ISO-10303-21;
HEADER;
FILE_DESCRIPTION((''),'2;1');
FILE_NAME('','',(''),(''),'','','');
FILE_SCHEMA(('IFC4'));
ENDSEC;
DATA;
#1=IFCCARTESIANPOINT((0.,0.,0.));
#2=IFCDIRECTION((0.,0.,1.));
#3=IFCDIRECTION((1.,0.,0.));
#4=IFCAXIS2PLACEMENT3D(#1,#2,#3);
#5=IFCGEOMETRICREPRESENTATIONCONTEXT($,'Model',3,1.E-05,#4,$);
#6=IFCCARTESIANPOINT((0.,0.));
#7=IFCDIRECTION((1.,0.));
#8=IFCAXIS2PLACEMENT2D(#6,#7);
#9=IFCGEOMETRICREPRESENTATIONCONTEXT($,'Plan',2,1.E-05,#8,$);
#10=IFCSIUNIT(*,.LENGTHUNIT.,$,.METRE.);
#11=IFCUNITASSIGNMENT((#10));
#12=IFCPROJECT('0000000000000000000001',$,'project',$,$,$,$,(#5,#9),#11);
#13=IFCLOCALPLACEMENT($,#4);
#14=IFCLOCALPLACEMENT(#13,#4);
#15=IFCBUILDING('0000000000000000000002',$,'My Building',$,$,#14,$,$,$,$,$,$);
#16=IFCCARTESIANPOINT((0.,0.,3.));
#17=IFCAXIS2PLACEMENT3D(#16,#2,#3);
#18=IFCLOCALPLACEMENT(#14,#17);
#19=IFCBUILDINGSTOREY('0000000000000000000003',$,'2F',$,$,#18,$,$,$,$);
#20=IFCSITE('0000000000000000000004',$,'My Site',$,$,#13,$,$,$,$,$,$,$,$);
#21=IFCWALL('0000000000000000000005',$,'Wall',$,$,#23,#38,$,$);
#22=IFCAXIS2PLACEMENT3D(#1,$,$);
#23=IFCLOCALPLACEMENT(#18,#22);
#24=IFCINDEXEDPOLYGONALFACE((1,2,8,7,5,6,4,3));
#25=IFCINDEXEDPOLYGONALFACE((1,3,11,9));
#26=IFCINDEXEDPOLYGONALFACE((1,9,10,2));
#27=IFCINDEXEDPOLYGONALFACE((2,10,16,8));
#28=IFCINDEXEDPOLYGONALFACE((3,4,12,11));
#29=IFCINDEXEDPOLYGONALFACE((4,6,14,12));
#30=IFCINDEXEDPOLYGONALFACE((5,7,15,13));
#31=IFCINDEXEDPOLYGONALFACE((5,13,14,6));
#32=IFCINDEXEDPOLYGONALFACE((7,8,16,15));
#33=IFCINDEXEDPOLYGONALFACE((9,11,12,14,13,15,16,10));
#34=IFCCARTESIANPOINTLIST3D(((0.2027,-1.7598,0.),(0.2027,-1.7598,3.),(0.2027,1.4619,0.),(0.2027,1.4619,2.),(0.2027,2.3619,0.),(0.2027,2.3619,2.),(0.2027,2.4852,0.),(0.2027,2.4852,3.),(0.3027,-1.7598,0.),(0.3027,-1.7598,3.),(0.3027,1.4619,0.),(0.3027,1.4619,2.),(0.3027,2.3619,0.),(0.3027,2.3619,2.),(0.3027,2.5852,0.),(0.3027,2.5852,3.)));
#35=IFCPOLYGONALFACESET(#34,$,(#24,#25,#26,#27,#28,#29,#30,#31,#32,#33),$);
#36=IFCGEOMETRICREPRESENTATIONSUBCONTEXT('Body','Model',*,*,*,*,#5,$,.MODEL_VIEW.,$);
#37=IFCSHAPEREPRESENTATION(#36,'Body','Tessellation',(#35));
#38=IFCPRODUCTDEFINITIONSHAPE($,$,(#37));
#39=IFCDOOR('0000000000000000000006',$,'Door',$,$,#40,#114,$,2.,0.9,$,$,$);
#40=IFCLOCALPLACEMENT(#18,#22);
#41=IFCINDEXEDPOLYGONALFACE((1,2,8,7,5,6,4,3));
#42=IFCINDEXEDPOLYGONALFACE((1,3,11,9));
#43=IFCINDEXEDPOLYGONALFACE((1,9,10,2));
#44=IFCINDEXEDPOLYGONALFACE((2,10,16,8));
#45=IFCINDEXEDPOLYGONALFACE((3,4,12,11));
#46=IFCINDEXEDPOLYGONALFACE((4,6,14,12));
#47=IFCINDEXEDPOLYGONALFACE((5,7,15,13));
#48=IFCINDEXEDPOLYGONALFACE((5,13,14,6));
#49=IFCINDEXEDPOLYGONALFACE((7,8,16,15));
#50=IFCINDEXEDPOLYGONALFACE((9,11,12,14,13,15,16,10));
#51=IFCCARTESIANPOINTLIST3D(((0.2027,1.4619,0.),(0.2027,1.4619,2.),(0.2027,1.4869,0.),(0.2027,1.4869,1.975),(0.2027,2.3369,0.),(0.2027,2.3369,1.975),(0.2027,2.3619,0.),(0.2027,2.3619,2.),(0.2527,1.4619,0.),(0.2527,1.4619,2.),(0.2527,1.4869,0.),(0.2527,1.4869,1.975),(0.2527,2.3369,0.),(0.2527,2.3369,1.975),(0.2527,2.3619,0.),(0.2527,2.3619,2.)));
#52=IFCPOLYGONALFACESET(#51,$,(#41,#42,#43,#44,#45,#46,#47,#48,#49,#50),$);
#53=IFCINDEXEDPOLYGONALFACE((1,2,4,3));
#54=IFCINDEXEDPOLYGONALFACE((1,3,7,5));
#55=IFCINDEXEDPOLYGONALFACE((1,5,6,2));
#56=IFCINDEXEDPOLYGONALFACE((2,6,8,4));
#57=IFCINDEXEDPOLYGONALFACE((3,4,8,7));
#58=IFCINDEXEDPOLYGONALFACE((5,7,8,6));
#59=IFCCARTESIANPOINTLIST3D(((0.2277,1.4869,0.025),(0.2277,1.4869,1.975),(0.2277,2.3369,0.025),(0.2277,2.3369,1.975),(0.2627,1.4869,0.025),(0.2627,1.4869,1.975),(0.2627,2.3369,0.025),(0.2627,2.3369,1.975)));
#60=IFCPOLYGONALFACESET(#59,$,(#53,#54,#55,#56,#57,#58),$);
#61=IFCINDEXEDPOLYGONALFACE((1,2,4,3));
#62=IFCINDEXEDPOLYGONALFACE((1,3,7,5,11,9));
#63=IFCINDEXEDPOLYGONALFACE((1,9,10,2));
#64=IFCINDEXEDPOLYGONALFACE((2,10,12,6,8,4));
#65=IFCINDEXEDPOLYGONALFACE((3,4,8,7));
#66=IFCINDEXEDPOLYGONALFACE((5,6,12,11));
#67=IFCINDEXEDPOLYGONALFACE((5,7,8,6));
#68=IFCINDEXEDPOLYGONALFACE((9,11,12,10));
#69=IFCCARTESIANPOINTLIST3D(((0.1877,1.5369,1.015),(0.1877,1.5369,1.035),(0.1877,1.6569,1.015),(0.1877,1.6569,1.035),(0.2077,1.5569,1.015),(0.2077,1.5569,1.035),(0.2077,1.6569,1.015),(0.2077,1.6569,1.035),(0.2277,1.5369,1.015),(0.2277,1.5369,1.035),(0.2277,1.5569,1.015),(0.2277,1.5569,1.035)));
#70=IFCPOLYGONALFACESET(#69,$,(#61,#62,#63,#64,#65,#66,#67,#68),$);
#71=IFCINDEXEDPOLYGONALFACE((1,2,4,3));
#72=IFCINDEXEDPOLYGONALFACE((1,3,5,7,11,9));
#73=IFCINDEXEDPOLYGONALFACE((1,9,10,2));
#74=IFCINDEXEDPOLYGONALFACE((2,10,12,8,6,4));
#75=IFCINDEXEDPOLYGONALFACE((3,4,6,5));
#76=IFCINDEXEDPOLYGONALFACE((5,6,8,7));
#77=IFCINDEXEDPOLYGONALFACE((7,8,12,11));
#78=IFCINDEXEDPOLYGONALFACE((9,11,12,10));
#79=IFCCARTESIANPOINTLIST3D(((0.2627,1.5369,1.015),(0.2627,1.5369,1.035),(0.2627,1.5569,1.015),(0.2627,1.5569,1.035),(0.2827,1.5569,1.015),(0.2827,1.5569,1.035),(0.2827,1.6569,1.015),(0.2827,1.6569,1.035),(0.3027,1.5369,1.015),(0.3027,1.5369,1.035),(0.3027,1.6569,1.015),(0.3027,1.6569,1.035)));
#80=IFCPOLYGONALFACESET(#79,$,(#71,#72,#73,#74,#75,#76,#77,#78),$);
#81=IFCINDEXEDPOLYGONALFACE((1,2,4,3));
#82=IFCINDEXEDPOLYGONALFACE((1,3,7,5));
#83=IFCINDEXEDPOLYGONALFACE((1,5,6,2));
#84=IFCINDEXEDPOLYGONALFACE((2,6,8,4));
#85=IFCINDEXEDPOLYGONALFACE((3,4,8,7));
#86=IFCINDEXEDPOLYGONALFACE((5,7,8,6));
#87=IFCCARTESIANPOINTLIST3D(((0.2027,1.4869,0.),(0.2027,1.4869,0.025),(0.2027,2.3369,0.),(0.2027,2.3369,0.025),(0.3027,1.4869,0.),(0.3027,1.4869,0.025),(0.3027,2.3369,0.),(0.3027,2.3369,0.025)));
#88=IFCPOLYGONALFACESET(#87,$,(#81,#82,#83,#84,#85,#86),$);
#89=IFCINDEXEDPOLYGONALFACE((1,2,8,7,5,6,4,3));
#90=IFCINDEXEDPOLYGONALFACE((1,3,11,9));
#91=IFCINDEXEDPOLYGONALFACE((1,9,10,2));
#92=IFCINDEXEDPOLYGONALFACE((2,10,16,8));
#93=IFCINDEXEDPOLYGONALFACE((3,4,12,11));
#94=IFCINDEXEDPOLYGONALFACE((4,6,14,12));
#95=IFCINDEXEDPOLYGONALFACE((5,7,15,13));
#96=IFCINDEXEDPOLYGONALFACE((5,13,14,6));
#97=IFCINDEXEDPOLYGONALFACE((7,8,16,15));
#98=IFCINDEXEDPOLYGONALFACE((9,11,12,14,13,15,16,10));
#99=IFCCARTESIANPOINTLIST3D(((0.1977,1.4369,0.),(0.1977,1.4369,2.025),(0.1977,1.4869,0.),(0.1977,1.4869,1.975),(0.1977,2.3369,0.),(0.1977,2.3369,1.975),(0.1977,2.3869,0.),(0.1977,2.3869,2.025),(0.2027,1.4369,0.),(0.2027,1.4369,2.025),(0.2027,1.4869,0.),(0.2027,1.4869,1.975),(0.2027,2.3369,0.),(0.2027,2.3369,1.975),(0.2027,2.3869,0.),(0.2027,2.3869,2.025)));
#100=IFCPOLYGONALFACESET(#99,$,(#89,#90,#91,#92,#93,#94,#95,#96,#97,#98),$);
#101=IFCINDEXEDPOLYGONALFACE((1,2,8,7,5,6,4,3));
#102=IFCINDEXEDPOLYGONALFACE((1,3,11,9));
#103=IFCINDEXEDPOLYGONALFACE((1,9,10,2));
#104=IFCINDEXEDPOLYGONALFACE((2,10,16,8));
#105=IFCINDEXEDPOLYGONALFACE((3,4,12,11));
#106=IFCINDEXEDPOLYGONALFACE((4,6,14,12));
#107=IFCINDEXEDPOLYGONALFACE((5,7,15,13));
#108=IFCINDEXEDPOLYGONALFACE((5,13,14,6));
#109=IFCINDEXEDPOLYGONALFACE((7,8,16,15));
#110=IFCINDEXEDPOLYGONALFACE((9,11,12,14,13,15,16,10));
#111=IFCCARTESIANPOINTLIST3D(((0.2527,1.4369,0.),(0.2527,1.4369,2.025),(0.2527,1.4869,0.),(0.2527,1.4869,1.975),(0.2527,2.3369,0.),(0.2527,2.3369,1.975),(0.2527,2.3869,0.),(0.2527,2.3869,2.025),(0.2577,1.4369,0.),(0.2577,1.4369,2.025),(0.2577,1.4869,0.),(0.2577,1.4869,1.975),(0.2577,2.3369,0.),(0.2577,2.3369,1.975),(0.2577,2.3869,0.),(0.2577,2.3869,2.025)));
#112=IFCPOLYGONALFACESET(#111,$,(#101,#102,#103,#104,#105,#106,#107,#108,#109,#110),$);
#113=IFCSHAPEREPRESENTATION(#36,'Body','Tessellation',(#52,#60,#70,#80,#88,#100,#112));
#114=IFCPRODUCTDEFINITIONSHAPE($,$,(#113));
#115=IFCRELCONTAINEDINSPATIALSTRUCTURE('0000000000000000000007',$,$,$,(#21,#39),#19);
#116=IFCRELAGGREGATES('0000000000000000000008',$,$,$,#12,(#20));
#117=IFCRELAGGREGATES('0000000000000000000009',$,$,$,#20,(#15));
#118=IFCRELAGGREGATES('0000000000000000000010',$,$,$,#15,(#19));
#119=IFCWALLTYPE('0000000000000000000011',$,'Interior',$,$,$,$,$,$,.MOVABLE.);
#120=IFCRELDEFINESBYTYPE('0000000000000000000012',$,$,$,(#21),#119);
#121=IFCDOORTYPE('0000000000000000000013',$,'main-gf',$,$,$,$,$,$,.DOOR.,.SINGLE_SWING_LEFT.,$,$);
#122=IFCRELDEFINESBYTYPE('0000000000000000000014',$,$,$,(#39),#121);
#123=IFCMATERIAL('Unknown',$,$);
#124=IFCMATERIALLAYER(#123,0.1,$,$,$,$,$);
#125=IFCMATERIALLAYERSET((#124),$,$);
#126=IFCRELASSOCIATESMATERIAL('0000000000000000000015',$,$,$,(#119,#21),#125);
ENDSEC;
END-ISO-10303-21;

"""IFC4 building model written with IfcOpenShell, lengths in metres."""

from ifc_helpers import new_model, entity, si_unit, frame, origin_with_axes, origin_2d_with_axis, place, context, subcontext, project, spatial, line, indexed_curve, outline, extrude, shape, source, transform, mapped, material, layer, layer_set, layer_usage, type_object, type_shapes, element, fill, save


model = new_model("IFC4")

# Units and contexts
model_context = context("Model", 3, precision=1e-05, world=origin_with_axes())
plan_context = context("Plan", 2, precision=1e-05, world=origin_2d_with_axis())
body_context_1 = subcontext(model_context, "Body", "Model", "MODEL_VIEW")
body_context_2 = subcontext(plan_context, "Body", "Plan", "PLAN_VIEW")
ifc_project = project(units=[si_unit("LENGTHUNIT", "METRE")], contexts=[model_context, plan_context])

# Site, building, storey
site_placement = place(None, origin_with_axes())
site = spatial("IfcSite", under=ifc_project, at=site_placement, Name="My Site")
building_placement = place(site_placement, origin_with_axes())
building = spatial("IfcBuilding", under=site, at=building_placement, Name="My Building")
storey_placement = place(building_placement, frame((0.0, 0.0, 3.0), z_axis=(0.0, 0.0, 1.0), x_axis=(1.0, 0.0, 0.0)))
storey = spatial("IfcBuildingStorey", under=building, at=storey_placement, Name="2F")

# Shared definitions
ifc_material = material(Name="Unknown")

# Shared definitions
ifc_layer_1 = layer(ifc_material, 0.1)
ifc_layer_set_1 = layer_set([ifc_layer_1])
wall_type = type_object("IfcWallType", Name="Interior", PredefinedType="MOVABLE", material=ifc_layer_set_1)

# Shared definitions
shared_shape_1 = source(origin_with_axes(), body_context_1, "Body", "SweptSolid", [
    extrude(outline(indexed_curve([(0.0, 0.0), (0.9, 0.0), (0.9, 2.0), (0.0, 2.0)], segments=[line(1, 2, 3, 4, 1)])), frame((0.0, -0.6, 0.0), z_axis=(0.0, -1.0, 0.0), x_axis=(1.0, 0.0, 0.0)), (0.0, 0.0, -1.0), 1.2),
])
door_type = type_object("IfcDoorType", Name="main-gf", OperationType="SINGLE_SWING_LEFT", PredefinedType="DOOR")
shared_shape_2 = source(origin_with_axes(), body_context_1, "Body", "SweptSolid", [
    extrude(outline(indexed_curve([(0.0, 0.0), (0.0, 2.0), (0.9, 2.0), (0.9, 0.0), (0.875, 0.0), (0.875, 1.975), (0.025, 1.975), (0.025, 0.0)], segments=[line(1, 2, 3, 4, 5, 6, 7, 8, 1)])), frame((0.0, 0.0, 0.0), z_axis=(0.0, -1.0, 0.0), x_axis=(1.0, 0.0, 0.0)), (0.0, 0.0, -1.0), 0.05),
    extrude(outline(indexed_curve([(0.0, 0.0), (0.85, 0.0), (0.85, 0.035), (0.0, 0.035)], segments=[line(1, 2, 3, 4, 1)])), frame((0.025, 0.025, 0.025), z_axis=(0.0, 0.0, 1.0), x_axis=(1.0, 0.0, 0.0)), (0.0, 0.0, 1.0), 1.95),
    extrude(outline(indexed_curve([(0.0, 0.0), (0.0, -0.04), (-0.12, -0.04), (-0.12, -0.02), (-0.02, -0.02), (-0.02, 0.0)], segments=[line(1, 2, 3, 4, 5, 6, 1)])), frame((0.825, 0.025, 1.015), z_axis=(0.0, 0.0, 1.0), x_axis=(1.0, 0.0, 0.0)), (0.0, 0.0, 1.0), 0.02),
    extrude(outline(indexed_curve([(0.0, 0.0), (0.0, 0.04), (-0.12, 0.04), (-0.12, 0.02), (-0.02, 0.02), (-0.02, 0.0)], segments=[line(1, 2, 3, 4, 5, 6, 1)])), frame((0.825, 0.06, 1.015), z_axis=(0.0, 0.0, 1.0), x_axis=(1.0, 0.0, 0.0)), (0.0, 0.0, 1.0), 0.02),
    extrude(outline(indexed_curve([(0.0, 0.0), (0.85, 0.0), (0.85, 0.1), (0.0, 0.1)], segments=[line(1, 2, 3, 4, 1)])), frame((0.025, 0.0, 0.0), z_axis=(0.0, 0.0, 1.0), x_axis=(1.0, 0.0, 0.0)), (0.0, 0.0, 1.0), 0.025),
    extrude(outline(indexed_curve([(0.0, 0.0), (0.0, 2.025), (0.95, 2.025), (0.95, 0.0), (0.9, 0.0), (0.9, 1.975), (0.05, 1.975), (0.05, 0.0)], segments=[line(1, 2, 3, 4, 5, 6, 7, 8, 1)])), frame((-0.025, -0.005, 0.0), z_axis=(0.0, -1.0, 0.0), x_axis=(1.0, 0.0, 0.0)), (0.0, 0.0, -1.0), 0.005),
    extrude(outline(indexed_curve([(0.0, 0.0), (0.0, 2.025), (0.95, 2.025), (0.95, 0.0), (0.9, 0.0), (0.9, 1.975), (0.05, 1.975), (0.05, 0.0)], segments=[line(1, 2, 3, 4, 5, 6, 7, 8, 1)])), frame((-0.025, 0.05, 0.0), z_axis=(0.0, -1.0, 0.0), x_axis=(1.0, 0.0, 0.0)), (0.0, 0.0, -1.0), 0.005),
])
shared_shape_3 = source(origin_with_axes(), body_context_2, "Body", "Curve2D", [
    entity("IfcIndexedPolyCurve", entity("IfcCartesianPointList2D", [[0.0, 0.0], [0.025, 0.0], [0.025, 0.05], [0.0, 0.05]]), [entity("IfcLineIndex", [1, 2, 3, 4, 1])]),
    entity("IfcIndexedPolyCurve", entity("IfcCartesianPointList2D", [[0.9, 0.0], [0.875, 0.0], [0.875, 0.05], [0.9, 0.05]]), [entity("IfcLineIndex", [1, 2, 3, 4, 1])]),
    entity("IfcIndexedPolyCurve", entity("IfcCartesianPointList2D", [[0.025, 0.05], [0.025, -0.8], [0.06, -0.8]])),
    entity("IfcTrimmedCurve", entity("IfcEllipse", entity("IfcAxis2Placement2D", entity("IfcCartesianPoint", [0.06, 0.05]), entity("IfcDirection", [1.0, 0.0])), 0.815, 0.85), [entity("IfcCartesianPoint", [0.06, -0.8])], [entity("IfcCartesianPoint", [0.06, 0.9])], True, "CARTESIAN"),
    entity("IfcIndexedPolyCurve", entity("IfcCartesianPointList2D", [[0.025, 0.05], [0.06, 0.05], [0.06, 0.9], [0.025, 0.9]]), [entity("IfcLineIndex", [1, 2, 3, 4, 1])]),
])
type_shapes(door_type, [shared_shape_2, shared_shape_3])

# Wall, opening, door
ifc_layer_usage_1 = layer_usage(ifc_layer_set_1, "AXIS2", "POSITIVE", 0.0)
wall_1_placement = place(storey_placement, frame((0.3027, -1.7598, 0.0), z_axis=(0.0, 0.0, 1.0), x_axis=(0.0, 1.0, 0.0)))
wall_1 = element("IfcWall", 1, at=wall_1_placement, inside=storey, type_object=wall_type, material=ifc_layer_usage_1, Name="Wall", context=body_context_1, shape_type="SweptSolid", body=[
    extrude(outline(indexed_curve([(0.0, 0.0), (0.0, 0.1), (4.245, 0.1), (4.345, 0.0)], segments=[line(1, 2, 3, 4, 1)])), origin_with_axes(), (0.0, 0.0, 1.0), 3.0),
])
opening_1_placement = place(wall_1_placement, frame((4.1217, 0.1, 0.0), z_axis=(0.0, 0.0, 1.0), x_axis=(-1.0, 0.0, 0.0)))
opening_1 = element("IfcOpeningElement", 2, at=opening_1_placement, cuts=wall_1, PredefinedType="OPENING", context=body_context_1, shape_type="MappedRepresentation", body=[
    mapped(shared_shape_1, transform((0.0, 0.0, 0.0), x_axis=(1.0, 0.0, 0.0), y_axis=(0.0, 1.0, 0.0), z_axis=(0.0, 0.0, 1.0), scale=1.0)),
])
door_1_placement = place(opening_1_placement, origin_with_axes())
door_1 = element("IfcDoor", 3, at=door_1_placement, inside=storey, type_object=door_type, Name="Door", OverallHeight=2.0, OverallWidth=0.9, shapes=[
    shape(body_context_1, "Body", "MappedRepresentation", [mapped(shared_shape_2, transform((0.0, 0.0, 0.0), x_axis=(1.0, 0.0, 0.0), y_axis=(0.0, 1.0, 0.0), z_axis=(0.0, 0.0, 1.0), scale=1.0))]),
    shape(body_context_2, "Body", "MappedRepresentation", [mapped(shared_shape_3, transform((0.0, 0.0, 0.0), x_axis=(1.0, 0.0, 0.0), y_axis=(0.0, 1.0, 0.0), z_axis=(0.0, 0.0, 1.0), scale=1.0))]),
])
fill(opening_1, door_1)

save(model, "model.ifc")
